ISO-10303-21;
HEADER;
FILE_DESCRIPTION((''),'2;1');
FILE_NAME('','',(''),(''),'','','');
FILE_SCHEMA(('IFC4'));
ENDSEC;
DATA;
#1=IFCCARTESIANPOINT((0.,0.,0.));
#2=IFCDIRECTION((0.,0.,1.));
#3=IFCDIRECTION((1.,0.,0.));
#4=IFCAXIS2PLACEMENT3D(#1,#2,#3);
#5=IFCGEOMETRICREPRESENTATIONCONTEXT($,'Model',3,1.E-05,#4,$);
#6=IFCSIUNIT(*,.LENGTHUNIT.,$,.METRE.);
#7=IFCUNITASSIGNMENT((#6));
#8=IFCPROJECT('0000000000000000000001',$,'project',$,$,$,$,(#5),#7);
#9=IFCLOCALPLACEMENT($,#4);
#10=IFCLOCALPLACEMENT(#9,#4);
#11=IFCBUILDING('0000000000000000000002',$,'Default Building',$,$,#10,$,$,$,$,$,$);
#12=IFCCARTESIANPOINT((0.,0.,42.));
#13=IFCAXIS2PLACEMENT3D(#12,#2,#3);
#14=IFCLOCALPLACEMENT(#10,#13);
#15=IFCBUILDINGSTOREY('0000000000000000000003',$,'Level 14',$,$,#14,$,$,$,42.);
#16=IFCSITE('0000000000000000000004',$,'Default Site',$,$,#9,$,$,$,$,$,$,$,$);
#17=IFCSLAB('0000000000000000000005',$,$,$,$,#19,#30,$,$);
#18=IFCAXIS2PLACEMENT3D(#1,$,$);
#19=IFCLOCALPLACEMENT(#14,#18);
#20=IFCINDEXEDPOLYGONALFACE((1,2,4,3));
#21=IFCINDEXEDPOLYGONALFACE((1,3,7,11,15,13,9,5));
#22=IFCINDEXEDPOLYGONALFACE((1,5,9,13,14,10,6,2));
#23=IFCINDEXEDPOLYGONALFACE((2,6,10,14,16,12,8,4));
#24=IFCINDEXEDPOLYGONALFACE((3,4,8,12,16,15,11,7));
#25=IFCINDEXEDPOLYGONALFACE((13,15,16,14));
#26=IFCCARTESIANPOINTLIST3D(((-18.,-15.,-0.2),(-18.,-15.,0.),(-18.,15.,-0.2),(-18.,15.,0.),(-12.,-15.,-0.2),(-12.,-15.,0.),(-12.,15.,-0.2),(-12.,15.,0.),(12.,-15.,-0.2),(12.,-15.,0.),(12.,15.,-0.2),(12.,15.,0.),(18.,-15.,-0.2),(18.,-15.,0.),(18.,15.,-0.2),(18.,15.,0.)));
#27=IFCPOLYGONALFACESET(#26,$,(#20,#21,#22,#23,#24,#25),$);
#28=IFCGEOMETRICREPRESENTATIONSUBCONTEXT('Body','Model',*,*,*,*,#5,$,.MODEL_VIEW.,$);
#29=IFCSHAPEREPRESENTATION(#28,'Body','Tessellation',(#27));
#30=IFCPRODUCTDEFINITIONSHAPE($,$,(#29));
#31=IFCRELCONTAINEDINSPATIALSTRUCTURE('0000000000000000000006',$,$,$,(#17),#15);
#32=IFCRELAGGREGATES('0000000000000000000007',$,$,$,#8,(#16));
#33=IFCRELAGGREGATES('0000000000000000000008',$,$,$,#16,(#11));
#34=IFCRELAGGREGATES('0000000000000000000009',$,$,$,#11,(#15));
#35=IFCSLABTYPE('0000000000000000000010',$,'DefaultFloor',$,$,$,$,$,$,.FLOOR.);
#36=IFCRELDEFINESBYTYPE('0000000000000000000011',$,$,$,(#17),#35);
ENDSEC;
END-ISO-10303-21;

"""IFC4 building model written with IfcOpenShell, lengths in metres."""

from ifc_helpers import new_model, si_unit, frame, origin_with_axes, place, context, subcontext, project, spatial, polyline, outline, extrude, type_object, element, save


model = new_model("IFC4")

# Units and contexts
model_context = context("Model", 3, precision=1e-05, world=origin_with_axes())
body_context = subcontext(model_context, "Body", "Model", "MODEL_VIEW")
ifc_project = project(units=[si_unit("LENGTHUNIT", "METRE")], contexts=[model_context])

# Site, building, storey
site_placement = place(None, origin_with_axes())
site = spatial("IfcSite", under=ifc_project, at=site_placement, Name="Default Site")
building_placement = place(site_placement, origin_with_axes())
building = spatial("IfcBuilding", under=site, at=building_placement, Name="Default Building")
storey_placement = place(building_placement, frame((0.0, 0.0, 42.0), z_axis=(0.0, 0.0, 1.0), x_axis=(1.0, 0.0, 0.0)))
storey = spatial("IfcBuildingStorey", under=building, at=storey_placement, Name="Level 14", Elevation=42.0)

# Slab
slab_type = type_object("IfcSlabType", Name="DefaultFloor", PredefinedType="FLOOR")
slab_placement = place(storey_placement, frame((0.0, 0.0, -42.0), z_axis=(0.0, 0.0, 1.0), x_axis=(1.0, 0.0, 0.0)))
element("IfcSlab", 1, at=slab_placement, inside=storey, type_object=slab_type, context=body_context, shape_type="SweptSolid", body=[
    extrude(outline(polyline([(-18.0, 15.0), (-12.0, 15.0), (12.0, 15.0), (18.0, 15.0), (18.0, -15.0), (12.0, -15.0), (-12.0, -15.0), (-18.0, -15.0), (-18.0, 15.0)])), frame((0.0, 0.0, 42.0), z_axis=(0.0, 0.0, 1.0), x_axis=(1.0, 0.0, 0.0)), (0.0, 0.0, -1.0), 0.2),
])

save(model, "model.ifc")
